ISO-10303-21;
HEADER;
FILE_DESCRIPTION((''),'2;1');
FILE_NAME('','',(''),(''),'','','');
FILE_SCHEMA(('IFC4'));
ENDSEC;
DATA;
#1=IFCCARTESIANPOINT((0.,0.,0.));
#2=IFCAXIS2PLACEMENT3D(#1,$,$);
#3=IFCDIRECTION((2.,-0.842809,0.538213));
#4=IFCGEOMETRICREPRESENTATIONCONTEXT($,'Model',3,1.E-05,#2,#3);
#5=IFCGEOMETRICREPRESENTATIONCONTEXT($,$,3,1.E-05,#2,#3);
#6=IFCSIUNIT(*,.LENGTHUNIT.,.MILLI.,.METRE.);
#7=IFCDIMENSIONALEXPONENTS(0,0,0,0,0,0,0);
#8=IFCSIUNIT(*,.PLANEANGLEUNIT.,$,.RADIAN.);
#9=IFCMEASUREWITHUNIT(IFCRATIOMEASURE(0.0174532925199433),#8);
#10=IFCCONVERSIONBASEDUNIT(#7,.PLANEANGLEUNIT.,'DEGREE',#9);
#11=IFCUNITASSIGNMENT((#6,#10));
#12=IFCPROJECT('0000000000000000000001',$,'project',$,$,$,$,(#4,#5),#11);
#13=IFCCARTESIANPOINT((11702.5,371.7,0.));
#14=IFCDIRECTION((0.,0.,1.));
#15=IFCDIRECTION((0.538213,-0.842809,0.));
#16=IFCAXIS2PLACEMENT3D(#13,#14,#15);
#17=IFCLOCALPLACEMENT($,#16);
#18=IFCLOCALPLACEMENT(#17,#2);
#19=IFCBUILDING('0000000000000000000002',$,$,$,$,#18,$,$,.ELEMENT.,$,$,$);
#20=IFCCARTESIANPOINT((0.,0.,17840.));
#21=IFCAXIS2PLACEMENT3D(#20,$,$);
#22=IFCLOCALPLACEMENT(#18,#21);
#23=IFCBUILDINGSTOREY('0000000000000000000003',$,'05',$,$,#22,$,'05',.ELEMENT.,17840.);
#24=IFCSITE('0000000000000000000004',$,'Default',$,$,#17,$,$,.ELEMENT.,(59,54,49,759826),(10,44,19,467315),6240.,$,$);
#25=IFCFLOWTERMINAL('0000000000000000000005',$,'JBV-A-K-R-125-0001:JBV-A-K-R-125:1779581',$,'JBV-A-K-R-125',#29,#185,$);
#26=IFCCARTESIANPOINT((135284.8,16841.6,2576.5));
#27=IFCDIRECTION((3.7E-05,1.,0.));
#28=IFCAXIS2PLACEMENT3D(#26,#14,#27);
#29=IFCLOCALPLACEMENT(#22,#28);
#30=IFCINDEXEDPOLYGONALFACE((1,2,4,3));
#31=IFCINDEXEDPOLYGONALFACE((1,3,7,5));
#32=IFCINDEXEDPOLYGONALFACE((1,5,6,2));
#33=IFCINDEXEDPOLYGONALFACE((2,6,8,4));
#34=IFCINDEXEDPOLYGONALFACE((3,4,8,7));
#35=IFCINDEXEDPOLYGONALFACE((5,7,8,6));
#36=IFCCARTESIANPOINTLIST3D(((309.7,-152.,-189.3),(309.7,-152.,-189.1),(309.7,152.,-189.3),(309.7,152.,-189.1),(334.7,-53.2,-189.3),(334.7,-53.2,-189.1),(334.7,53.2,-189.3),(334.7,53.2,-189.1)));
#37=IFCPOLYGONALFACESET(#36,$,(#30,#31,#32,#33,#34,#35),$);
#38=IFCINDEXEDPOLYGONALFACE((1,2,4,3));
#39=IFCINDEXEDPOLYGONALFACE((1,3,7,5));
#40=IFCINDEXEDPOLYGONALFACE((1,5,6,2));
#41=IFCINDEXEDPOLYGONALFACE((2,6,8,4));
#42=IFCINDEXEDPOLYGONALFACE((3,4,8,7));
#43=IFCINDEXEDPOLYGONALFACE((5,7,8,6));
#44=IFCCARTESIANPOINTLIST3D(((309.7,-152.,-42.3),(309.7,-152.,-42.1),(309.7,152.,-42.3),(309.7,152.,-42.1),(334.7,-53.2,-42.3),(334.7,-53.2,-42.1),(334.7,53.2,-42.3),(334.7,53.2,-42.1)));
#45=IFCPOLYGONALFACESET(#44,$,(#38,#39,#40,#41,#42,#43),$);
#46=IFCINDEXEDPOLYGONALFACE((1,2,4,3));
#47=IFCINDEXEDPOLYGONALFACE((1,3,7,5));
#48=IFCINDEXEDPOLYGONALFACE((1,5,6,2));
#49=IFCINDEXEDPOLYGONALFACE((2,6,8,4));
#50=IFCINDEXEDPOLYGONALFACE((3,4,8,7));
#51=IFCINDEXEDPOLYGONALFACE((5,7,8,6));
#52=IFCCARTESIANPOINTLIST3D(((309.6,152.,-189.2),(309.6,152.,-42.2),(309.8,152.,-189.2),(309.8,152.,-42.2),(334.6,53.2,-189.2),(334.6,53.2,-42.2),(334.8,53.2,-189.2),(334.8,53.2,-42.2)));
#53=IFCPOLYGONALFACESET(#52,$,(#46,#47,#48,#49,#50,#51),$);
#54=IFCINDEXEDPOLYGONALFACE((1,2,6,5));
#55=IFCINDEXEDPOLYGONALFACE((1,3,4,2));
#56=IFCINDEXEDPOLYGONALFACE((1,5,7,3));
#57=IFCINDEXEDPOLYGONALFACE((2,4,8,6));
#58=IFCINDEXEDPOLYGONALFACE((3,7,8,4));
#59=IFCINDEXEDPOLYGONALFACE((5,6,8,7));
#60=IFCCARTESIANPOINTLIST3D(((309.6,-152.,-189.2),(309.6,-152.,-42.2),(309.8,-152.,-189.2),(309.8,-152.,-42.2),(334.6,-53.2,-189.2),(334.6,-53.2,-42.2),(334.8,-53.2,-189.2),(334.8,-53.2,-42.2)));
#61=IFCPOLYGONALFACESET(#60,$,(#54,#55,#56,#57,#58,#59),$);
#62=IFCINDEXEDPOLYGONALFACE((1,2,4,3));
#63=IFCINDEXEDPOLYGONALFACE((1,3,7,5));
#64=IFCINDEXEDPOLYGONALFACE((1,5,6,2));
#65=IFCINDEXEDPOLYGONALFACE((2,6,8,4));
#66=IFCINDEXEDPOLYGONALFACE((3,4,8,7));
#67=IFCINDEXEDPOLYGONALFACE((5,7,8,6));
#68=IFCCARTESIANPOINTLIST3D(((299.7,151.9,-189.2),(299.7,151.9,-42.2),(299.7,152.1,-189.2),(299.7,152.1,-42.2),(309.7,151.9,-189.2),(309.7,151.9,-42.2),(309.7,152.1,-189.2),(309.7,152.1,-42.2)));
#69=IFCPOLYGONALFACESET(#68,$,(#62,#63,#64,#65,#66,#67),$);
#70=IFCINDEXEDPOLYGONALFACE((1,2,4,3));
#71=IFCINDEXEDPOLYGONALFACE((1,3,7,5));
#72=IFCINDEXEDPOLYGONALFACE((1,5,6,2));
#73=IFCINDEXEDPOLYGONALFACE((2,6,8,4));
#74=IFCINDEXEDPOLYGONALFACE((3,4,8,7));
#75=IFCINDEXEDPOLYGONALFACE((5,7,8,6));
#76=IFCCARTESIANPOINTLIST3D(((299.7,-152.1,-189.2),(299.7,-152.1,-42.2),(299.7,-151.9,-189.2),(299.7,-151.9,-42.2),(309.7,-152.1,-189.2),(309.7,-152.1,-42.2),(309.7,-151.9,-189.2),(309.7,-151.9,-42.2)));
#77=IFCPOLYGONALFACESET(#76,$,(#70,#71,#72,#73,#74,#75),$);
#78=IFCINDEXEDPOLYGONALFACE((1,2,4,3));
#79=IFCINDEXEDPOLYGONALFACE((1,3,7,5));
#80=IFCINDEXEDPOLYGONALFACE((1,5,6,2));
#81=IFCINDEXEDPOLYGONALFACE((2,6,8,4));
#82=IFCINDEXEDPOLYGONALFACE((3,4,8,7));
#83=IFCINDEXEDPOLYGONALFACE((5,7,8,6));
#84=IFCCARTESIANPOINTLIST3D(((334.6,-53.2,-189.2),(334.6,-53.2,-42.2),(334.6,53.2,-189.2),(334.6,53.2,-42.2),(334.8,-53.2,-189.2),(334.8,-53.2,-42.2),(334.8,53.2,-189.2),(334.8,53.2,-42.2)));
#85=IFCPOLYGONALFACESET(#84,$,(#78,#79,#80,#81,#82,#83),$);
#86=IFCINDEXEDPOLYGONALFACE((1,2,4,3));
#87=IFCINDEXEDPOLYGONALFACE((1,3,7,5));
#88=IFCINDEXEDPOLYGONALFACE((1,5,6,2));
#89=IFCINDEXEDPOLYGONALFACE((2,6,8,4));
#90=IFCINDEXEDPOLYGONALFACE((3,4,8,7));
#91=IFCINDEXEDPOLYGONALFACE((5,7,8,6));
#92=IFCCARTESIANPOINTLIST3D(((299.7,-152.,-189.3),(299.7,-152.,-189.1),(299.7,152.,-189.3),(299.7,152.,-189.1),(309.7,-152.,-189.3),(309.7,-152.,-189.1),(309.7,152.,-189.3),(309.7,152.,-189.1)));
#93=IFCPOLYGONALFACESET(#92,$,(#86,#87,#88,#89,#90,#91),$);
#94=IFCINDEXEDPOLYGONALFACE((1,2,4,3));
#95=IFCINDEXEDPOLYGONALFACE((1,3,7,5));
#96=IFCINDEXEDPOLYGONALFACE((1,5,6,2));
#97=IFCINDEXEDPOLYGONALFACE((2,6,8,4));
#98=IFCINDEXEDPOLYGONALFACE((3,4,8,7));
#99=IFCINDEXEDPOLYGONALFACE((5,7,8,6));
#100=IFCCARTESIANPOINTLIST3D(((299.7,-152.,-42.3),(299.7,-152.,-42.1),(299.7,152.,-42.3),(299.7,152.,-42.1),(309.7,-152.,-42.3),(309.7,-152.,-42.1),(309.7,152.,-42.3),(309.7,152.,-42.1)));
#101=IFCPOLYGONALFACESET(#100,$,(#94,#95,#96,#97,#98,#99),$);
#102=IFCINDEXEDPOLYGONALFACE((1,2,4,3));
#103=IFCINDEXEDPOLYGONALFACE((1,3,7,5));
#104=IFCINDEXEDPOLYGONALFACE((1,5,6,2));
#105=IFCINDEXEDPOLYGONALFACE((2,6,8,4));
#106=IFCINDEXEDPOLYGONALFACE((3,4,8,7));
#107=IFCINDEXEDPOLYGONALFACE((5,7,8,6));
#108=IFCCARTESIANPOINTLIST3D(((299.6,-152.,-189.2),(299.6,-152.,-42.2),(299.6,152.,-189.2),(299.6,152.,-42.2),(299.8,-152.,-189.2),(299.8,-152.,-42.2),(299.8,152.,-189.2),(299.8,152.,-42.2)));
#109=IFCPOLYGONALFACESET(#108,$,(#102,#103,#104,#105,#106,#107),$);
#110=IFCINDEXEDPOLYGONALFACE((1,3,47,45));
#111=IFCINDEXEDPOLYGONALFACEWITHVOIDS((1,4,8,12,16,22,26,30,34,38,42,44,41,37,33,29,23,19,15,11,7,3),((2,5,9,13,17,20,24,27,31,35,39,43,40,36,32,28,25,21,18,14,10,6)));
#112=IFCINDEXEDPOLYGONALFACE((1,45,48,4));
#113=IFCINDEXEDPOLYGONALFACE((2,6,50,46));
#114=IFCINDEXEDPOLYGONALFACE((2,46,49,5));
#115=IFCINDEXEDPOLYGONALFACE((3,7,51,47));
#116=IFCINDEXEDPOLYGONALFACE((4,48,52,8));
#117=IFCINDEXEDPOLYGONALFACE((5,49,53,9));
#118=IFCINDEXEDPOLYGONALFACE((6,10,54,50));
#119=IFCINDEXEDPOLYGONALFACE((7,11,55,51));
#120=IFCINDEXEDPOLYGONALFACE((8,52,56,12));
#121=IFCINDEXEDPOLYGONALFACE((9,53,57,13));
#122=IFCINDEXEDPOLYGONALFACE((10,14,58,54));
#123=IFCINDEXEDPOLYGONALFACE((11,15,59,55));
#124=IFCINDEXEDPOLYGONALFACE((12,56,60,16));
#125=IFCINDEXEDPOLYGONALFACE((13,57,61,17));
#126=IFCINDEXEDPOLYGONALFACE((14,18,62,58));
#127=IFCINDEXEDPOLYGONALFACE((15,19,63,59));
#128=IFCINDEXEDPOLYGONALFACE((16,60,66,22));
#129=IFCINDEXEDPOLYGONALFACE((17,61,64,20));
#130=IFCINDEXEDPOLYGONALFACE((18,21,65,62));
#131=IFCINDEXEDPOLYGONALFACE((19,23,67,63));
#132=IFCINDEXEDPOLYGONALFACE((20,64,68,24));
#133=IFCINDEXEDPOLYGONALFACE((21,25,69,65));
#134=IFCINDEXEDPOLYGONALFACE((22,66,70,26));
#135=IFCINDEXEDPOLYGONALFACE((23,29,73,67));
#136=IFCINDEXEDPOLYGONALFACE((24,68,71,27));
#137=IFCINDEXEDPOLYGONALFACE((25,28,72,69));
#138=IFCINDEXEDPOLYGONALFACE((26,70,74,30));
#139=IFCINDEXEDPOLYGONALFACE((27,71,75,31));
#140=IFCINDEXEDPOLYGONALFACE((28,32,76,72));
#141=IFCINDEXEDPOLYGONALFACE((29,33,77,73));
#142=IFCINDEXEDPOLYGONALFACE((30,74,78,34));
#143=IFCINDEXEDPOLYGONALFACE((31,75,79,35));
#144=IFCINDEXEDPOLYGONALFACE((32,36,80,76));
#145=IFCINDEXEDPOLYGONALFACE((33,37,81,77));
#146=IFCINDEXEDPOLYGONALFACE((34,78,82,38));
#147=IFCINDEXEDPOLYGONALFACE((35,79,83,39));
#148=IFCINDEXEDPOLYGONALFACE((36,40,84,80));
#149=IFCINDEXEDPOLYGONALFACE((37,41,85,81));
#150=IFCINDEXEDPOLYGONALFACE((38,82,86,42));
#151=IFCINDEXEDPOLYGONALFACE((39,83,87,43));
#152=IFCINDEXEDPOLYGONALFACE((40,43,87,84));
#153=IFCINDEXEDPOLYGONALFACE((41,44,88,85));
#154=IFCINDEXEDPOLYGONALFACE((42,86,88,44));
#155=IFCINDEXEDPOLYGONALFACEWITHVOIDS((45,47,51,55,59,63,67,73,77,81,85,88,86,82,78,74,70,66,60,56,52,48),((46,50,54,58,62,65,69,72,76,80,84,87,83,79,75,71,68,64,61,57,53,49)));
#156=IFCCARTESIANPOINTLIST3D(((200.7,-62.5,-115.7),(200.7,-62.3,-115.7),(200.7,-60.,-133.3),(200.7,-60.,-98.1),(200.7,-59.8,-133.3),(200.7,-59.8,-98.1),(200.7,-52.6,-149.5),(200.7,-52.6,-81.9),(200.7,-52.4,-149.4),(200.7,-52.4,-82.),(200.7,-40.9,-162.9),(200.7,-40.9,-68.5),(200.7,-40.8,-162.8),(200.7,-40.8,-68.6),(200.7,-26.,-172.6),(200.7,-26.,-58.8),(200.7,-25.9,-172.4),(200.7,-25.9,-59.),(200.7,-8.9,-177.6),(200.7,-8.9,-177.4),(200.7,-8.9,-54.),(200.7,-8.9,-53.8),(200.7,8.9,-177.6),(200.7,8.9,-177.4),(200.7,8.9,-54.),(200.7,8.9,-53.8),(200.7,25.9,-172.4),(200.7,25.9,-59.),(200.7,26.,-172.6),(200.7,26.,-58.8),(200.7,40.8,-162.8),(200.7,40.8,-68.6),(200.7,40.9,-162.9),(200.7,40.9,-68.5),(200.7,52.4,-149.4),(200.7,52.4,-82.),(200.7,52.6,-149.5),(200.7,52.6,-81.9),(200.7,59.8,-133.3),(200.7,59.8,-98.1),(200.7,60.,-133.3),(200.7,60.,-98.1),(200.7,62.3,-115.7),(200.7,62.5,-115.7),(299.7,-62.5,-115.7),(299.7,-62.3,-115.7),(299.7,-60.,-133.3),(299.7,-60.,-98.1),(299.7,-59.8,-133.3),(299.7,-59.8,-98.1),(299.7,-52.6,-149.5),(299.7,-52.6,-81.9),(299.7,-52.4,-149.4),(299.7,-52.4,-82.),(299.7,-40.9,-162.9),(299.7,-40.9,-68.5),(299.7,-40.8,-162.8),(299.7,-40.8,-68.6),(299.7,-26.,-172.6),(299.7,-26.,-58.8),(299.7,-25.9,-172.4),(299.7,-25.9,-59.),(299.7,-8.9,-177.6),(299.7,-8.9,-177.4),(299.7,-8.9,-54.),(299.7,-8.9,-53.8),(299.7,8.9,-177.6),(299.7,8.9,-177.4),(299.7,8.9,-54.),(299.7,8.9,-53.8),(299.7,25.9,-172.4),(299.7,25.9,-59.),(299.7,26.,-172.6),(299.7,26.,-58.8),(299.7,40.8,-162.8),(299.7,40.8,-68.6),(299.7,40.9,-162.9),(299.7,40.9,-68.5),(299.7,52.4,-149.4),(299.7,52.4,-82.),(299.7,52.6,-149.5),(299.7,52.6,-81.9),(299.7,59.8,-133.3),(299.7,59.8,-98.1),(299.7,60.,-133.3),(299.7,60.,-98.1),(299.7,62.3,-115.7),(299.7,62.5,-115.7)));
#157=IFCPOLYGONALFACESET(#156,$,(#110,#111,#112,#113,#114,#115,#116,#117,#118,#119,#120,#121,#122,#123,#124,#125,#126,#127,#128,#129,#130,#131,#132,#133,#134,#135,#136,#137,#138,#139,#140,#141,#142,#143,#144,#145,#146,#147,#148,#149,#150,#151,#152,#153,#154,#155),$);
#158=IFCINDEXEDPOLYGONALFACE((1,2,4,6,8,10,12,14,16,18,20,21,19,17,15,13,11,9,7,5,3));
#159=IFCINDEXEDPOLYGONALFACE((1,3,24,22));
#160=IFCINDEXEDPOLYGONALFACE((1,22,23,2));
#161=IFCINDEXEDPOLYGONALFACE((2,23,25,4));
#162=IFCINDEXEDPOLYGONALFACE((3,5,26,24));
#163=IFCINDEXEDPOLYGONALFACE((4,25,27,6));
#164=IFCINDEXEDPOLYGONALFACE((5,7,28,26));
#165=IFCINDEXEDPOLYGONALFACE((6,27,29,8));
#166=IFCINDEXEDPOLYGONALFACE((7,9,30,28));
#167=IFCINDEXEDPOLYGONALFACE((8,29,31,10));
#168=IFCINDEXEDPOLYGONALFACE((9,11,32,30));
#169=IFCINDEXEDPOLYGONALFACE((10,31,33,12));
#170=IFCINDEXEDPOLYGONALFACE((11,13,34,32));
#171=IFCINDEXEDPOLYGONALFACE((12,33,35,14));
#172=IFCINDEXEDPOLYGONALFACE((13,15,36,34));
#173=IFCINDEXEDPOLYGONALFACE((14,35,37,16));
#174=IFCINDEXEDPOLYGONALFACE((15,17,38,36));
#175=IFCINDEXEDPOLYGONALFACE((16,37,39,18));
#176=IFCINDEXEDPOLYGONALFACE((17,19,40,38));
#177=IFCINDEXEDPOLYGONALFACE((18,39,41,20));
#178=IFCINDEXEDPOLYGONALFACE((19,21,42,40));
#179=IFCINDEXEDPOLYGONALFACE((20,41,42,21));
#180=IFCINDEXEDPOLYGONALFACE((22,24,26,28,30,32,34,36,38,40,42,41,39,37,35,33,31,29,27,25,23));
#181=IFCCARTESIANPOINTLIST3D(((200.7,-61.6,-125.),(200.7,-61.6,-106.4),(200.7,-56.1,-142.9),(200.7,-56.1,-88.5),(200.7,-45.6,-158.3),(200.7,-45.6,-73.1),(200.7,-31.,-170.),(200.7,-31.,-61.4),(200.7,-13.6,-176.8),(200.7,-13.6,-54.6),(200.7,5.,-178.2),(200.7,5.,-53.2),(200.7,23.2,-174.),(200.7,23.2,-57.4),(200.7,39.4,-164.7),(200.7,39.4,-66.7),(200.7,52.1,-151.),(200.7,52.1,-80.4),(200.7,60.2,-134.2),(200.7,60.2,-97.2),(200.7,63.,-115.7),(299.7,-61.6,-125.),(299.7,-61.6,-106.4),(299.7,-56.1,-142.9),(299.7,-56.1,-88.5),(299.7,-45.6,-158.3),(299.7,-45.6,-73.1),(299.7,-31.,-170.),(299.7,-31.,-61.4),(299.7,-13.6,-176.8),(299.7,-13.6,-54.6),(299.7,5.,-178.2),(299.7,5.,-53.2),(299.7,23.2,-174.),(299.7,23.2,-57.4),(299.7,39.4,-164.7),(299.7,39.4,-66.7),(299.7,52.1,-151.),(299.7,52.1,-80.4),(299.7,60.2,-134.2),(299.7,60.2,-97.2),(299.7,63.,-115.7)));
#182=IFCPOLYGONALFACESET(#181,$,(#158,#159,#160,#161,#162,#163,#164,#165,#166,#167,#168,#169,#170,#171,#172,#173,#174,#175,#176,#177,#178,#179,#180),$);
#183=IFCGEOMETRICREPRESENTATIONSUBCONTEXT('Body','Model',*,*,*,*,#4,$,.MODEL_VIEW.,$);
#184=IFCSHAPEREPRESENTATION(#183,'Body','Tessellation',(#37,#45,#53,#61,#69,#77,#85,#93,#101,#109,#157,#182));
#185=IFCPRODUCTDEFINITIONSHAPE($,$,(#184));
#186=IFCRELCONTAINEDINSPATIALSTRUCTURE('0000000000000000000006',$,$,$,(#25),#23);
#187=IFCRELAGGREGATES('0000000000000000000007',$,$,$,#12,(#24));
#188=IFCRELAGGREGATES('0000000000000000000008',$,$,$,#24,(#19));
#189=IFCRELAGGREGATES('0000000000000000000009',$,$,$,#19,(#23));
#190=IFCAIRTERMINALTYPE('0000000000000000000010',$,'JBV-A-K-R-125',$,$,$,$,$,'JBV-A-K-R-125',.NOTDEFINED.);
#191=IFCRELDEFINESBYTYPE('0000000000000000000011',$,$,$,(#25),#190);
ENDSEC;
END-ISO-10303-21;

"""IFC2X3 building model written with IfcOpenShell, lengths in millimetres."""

from ifc_helpers import new_model, entity, si_unit, converted_unit, direction, frame, frame_2d, origin, origin_2d_with_axis, place, context, subcontext, project, spatial, polyline, circle_curve, parameter, trimmed, segment, composite_curve, rectangle, circle, outline, extrude, source, transform, mapped, type_object, type_shapes, element, save


model = new_model("IFC2X3")

# Units and contexts
model_context = context("Model", 3, precision=1e-05, world=origin(), true_north=direction((2.0, -0.842809, 0.538213)))
context_of_model = context(None, 3, precision=1e-05, world=origin(), true_north=direction((2.0, -0.842809, 0.538213)))
body_context = subcontext(model_context, "Body", "Model", "MODEL_VIEW")
ifc_project = project(units=[si_unit("LENGTHUNIT", "METRE", prefix="MILLI"), converted_unit("PLANEANGLEUNIT", "DEGREE", entity("IfcRatioMeasure", 0.0174532925199433), si_unit("PLANEANGLEUNIT", "RADIAN"), dimensions=[0, 0, 0, 0, 0, 0, 0])], contexts=[model_context, context_of_model])

# Site, building, storey
site_placement = place(None, frame((11702.5, 371.7, 0.0), z_axis=(0.0, 0.0, 1.0), x_axis=(0.538213, -0.842809, 0.0)))
site = spatial("IfcSite", under=ifc_project, at=site_placement, Name="Default", CompositionType="ELEMENT", RefLatitude=(59, 54, 49, 759826), RefLongitude=(10, 44, 19, 467315), RefElevation=6240.0)
building_placement = place(site_placement, origin())
building = spatial("IfcBuilding", under=site, at=building_placement, CompositionType="ELEMENT")
storey_placement = place(building_placement, frame((0.0, 0.0, 17840.0)))
storey = spatial("IfcBuildingStorey", under=building, at=storey_placement, Name="05", LongName="05", CompositionType="ELEMENT", Elevation=17840.0)

# Flow terminal
air_terminal_type_1 = type_object("IfcAirTerminalType", Name="JBV-A-K-R-125", ElementType="JBV-A-K-R-125", PredefinedType="NOTDEFINED")
shared_shape_1 = source(origin(), body_context, "Body", "SweptSolid", [
    extrude(outline(polyline([(-152.0, -12.5), (152.0, -12.5), (53.2, 12.5), (-53.2, 12.5), (-152.0, -12.5)])), frame((322.2, 0.0, -189.3), z_axis=(0.0, 0.0, 1.0), x_axis=(0.0, -1.0, 0.0)), (0.0, 0.0, 1.0), 0.2),
    extrude(outline(polyline([(-152.0, -12.5), (152.0, -12.5), (53.2, 12.5), (-53.2, 12.5), (-152.0, -12.5)])), frame((322.2, 0.0, -42.3), z_axis=(0.0, 0.0, 1.0), x_axis=(0.0, -1.0, 0.0)), (0.0, 0.0, 1.0), 0.2),
    extrude(rectangle(XDim=0.2, YDim=101.9, at=frame_2d((0.0, 0.0), x_axis=(1.0, 0.0))), frame((322.2, 102.6, -189.2), z_axis=(0.0, 0.0, 1.0), x_axis=(0.969446, 0.245305, 0.0)), (0.0, 0.0, 1.0), 147.0),
    extrude(rectangle(XDim=0.2, YDim=101.9, at=frame_2d((0.0, 0.0), x_axis=(1.0, 0.0))), frame((322.2, -102.6, -189.2), z_axis=(0.0, 0.0, 1.0), x_axis=(-0.969446, 0.245305, 0.0)), (0.0, 0.0, 1.0), 147.0),
    extrude(rectangle(XDim=0.2, YDim=10.0, at=frame_2d((0.0, 0.0), x_axis=(1.0, 0.0))), frame((304.7, 152.0, -189.2), z_axis=(0.0, 0.0, 1.0), x_axis=(0.0, 1.0, 0.0)), (0.0, 0.0, 1.0), 147.0),
    extrude(rectangle(XDim=0.2, YDim=10.0, at=frame_2d((0.0, 0.0), x_axis=(1.0, 0.0))), frame((304.7, -152.0, -189.2), z_axis=(0.0, 0.0, 1.0), x_axis=(0.0, 1.0, 0.0)), (0.0, 0.0, 1.0), 147.0),
    extrude(rectangle(XDim=0.2, YDim=106.4, at=frame_2d((0.0, 0.0), x_axis=(1.0, 0.0))), frame((334.7, 0.0, -189.2)), (0.0, 0.0, 1.0), 147.0),
    extrude(rectangle(XDim=304.0, YDim=10.0, at=frame_2d((0.0, 0.0), x_axis=(1.0, 0.0))), frame((304.7, 0.0, -189.3), z_axis=(0.0, 0.0, 1.0), x_axis=(0.0, -1.0, 0.0)), (0.0, 0.0, 1.0), 0.2),
    extrude(rectangle(XDim=304.0, YDim=10.0, at=frame_2d((0.0, 0.0), x_axis=(1.0, 0.0))), frame((304.7, 0.0, -42.3), z_axis=(0.0, 0.0, 1.0), x_axis=(0.0, -1.0, 0.0)), (0.0, 0.0, 1.0), 0.2),
    extrude(rectangle(XDim=0.2, YDim=304.0, at=frame_2d((0.0, 0.0), x_axis=(1.0, 0.0))), frame((299.7, 0.0, -189.2)), (0.0, 0.0, 1.0), 147.0),
    extrude(outline(composite_curve([segment(trimmed(circle_curve(origin_2d_with_axis(), 62.5), [parameter(0.0)], [parameter(180.0)], True, "PARAMETER"), True, "CONTINUOUS"), segment(trimmed(circle_curve(origin_2d_with_axis(), 62.5), [parameter(180.0)], [parameter(360.0)], True, "PARAMETER"), True, "CONTINUOUS")], self_intersect=False), holes=[composite_curve([segment(trimmed(circle_curve(origin_2d_with_axis(), 62.3), [parameter(180.0)], [parameter(360.0)], True, "PARAMETER"), False, "CONTINUOUS"), segment(trimmed(circle_curve(origin_2d_with_axis(), 62.3), [parameter(0.0)], [parameter(180.0)], True, "PARAMETER"), False, "CONTINUOUS")], self_intersect=False)]), frame((200.7, 0.0, -115.7), z_axis=(1.0, 0.0, 0.0), x_axis=(0.0, 1.0, 0.0)), (0.0, 0.0, 1.0), 99.0),
    extrude(circle(Radius=62.6, at=frame_2d((0.0, 0.0), x_axis=(1.0, 0.0))), frame((200.7, 0.3, -115.7), z_axis=(1.0, 0.0, 0.0), x_axis=(0.0, 1.0, 0.0)), (0.0, 0.0, 1.0), 99.0),
])
type_shapes(air_terminal_type_1, [shared_shape_1])
for number, where, z_axis, x_axis, name in (
    (1, (135284.8, 16841.6, 2576.5), (0.0, 0.0, 1.0), (0.000037, 1.0, 0.0), "JBV-A-K-R-125-0001:JBV-A-K-R-125:1779581"),
):
    element("IfcFlowTerminal", number, at=place(storey_placement, frame(where, z_axis=z_axis, x_axis=x_axis)), inside=storey, type_object=air_terminal_type_1, Name=name, ObjectType="JBV-A-K-R-125", context=body_context, shape_type="MappedRepresentation", body=[
        mapped(shared_shape_1, transform((0.0, 0.0, 0.0), scale=1.0)),
    ])

save(model, "model.ifc")
